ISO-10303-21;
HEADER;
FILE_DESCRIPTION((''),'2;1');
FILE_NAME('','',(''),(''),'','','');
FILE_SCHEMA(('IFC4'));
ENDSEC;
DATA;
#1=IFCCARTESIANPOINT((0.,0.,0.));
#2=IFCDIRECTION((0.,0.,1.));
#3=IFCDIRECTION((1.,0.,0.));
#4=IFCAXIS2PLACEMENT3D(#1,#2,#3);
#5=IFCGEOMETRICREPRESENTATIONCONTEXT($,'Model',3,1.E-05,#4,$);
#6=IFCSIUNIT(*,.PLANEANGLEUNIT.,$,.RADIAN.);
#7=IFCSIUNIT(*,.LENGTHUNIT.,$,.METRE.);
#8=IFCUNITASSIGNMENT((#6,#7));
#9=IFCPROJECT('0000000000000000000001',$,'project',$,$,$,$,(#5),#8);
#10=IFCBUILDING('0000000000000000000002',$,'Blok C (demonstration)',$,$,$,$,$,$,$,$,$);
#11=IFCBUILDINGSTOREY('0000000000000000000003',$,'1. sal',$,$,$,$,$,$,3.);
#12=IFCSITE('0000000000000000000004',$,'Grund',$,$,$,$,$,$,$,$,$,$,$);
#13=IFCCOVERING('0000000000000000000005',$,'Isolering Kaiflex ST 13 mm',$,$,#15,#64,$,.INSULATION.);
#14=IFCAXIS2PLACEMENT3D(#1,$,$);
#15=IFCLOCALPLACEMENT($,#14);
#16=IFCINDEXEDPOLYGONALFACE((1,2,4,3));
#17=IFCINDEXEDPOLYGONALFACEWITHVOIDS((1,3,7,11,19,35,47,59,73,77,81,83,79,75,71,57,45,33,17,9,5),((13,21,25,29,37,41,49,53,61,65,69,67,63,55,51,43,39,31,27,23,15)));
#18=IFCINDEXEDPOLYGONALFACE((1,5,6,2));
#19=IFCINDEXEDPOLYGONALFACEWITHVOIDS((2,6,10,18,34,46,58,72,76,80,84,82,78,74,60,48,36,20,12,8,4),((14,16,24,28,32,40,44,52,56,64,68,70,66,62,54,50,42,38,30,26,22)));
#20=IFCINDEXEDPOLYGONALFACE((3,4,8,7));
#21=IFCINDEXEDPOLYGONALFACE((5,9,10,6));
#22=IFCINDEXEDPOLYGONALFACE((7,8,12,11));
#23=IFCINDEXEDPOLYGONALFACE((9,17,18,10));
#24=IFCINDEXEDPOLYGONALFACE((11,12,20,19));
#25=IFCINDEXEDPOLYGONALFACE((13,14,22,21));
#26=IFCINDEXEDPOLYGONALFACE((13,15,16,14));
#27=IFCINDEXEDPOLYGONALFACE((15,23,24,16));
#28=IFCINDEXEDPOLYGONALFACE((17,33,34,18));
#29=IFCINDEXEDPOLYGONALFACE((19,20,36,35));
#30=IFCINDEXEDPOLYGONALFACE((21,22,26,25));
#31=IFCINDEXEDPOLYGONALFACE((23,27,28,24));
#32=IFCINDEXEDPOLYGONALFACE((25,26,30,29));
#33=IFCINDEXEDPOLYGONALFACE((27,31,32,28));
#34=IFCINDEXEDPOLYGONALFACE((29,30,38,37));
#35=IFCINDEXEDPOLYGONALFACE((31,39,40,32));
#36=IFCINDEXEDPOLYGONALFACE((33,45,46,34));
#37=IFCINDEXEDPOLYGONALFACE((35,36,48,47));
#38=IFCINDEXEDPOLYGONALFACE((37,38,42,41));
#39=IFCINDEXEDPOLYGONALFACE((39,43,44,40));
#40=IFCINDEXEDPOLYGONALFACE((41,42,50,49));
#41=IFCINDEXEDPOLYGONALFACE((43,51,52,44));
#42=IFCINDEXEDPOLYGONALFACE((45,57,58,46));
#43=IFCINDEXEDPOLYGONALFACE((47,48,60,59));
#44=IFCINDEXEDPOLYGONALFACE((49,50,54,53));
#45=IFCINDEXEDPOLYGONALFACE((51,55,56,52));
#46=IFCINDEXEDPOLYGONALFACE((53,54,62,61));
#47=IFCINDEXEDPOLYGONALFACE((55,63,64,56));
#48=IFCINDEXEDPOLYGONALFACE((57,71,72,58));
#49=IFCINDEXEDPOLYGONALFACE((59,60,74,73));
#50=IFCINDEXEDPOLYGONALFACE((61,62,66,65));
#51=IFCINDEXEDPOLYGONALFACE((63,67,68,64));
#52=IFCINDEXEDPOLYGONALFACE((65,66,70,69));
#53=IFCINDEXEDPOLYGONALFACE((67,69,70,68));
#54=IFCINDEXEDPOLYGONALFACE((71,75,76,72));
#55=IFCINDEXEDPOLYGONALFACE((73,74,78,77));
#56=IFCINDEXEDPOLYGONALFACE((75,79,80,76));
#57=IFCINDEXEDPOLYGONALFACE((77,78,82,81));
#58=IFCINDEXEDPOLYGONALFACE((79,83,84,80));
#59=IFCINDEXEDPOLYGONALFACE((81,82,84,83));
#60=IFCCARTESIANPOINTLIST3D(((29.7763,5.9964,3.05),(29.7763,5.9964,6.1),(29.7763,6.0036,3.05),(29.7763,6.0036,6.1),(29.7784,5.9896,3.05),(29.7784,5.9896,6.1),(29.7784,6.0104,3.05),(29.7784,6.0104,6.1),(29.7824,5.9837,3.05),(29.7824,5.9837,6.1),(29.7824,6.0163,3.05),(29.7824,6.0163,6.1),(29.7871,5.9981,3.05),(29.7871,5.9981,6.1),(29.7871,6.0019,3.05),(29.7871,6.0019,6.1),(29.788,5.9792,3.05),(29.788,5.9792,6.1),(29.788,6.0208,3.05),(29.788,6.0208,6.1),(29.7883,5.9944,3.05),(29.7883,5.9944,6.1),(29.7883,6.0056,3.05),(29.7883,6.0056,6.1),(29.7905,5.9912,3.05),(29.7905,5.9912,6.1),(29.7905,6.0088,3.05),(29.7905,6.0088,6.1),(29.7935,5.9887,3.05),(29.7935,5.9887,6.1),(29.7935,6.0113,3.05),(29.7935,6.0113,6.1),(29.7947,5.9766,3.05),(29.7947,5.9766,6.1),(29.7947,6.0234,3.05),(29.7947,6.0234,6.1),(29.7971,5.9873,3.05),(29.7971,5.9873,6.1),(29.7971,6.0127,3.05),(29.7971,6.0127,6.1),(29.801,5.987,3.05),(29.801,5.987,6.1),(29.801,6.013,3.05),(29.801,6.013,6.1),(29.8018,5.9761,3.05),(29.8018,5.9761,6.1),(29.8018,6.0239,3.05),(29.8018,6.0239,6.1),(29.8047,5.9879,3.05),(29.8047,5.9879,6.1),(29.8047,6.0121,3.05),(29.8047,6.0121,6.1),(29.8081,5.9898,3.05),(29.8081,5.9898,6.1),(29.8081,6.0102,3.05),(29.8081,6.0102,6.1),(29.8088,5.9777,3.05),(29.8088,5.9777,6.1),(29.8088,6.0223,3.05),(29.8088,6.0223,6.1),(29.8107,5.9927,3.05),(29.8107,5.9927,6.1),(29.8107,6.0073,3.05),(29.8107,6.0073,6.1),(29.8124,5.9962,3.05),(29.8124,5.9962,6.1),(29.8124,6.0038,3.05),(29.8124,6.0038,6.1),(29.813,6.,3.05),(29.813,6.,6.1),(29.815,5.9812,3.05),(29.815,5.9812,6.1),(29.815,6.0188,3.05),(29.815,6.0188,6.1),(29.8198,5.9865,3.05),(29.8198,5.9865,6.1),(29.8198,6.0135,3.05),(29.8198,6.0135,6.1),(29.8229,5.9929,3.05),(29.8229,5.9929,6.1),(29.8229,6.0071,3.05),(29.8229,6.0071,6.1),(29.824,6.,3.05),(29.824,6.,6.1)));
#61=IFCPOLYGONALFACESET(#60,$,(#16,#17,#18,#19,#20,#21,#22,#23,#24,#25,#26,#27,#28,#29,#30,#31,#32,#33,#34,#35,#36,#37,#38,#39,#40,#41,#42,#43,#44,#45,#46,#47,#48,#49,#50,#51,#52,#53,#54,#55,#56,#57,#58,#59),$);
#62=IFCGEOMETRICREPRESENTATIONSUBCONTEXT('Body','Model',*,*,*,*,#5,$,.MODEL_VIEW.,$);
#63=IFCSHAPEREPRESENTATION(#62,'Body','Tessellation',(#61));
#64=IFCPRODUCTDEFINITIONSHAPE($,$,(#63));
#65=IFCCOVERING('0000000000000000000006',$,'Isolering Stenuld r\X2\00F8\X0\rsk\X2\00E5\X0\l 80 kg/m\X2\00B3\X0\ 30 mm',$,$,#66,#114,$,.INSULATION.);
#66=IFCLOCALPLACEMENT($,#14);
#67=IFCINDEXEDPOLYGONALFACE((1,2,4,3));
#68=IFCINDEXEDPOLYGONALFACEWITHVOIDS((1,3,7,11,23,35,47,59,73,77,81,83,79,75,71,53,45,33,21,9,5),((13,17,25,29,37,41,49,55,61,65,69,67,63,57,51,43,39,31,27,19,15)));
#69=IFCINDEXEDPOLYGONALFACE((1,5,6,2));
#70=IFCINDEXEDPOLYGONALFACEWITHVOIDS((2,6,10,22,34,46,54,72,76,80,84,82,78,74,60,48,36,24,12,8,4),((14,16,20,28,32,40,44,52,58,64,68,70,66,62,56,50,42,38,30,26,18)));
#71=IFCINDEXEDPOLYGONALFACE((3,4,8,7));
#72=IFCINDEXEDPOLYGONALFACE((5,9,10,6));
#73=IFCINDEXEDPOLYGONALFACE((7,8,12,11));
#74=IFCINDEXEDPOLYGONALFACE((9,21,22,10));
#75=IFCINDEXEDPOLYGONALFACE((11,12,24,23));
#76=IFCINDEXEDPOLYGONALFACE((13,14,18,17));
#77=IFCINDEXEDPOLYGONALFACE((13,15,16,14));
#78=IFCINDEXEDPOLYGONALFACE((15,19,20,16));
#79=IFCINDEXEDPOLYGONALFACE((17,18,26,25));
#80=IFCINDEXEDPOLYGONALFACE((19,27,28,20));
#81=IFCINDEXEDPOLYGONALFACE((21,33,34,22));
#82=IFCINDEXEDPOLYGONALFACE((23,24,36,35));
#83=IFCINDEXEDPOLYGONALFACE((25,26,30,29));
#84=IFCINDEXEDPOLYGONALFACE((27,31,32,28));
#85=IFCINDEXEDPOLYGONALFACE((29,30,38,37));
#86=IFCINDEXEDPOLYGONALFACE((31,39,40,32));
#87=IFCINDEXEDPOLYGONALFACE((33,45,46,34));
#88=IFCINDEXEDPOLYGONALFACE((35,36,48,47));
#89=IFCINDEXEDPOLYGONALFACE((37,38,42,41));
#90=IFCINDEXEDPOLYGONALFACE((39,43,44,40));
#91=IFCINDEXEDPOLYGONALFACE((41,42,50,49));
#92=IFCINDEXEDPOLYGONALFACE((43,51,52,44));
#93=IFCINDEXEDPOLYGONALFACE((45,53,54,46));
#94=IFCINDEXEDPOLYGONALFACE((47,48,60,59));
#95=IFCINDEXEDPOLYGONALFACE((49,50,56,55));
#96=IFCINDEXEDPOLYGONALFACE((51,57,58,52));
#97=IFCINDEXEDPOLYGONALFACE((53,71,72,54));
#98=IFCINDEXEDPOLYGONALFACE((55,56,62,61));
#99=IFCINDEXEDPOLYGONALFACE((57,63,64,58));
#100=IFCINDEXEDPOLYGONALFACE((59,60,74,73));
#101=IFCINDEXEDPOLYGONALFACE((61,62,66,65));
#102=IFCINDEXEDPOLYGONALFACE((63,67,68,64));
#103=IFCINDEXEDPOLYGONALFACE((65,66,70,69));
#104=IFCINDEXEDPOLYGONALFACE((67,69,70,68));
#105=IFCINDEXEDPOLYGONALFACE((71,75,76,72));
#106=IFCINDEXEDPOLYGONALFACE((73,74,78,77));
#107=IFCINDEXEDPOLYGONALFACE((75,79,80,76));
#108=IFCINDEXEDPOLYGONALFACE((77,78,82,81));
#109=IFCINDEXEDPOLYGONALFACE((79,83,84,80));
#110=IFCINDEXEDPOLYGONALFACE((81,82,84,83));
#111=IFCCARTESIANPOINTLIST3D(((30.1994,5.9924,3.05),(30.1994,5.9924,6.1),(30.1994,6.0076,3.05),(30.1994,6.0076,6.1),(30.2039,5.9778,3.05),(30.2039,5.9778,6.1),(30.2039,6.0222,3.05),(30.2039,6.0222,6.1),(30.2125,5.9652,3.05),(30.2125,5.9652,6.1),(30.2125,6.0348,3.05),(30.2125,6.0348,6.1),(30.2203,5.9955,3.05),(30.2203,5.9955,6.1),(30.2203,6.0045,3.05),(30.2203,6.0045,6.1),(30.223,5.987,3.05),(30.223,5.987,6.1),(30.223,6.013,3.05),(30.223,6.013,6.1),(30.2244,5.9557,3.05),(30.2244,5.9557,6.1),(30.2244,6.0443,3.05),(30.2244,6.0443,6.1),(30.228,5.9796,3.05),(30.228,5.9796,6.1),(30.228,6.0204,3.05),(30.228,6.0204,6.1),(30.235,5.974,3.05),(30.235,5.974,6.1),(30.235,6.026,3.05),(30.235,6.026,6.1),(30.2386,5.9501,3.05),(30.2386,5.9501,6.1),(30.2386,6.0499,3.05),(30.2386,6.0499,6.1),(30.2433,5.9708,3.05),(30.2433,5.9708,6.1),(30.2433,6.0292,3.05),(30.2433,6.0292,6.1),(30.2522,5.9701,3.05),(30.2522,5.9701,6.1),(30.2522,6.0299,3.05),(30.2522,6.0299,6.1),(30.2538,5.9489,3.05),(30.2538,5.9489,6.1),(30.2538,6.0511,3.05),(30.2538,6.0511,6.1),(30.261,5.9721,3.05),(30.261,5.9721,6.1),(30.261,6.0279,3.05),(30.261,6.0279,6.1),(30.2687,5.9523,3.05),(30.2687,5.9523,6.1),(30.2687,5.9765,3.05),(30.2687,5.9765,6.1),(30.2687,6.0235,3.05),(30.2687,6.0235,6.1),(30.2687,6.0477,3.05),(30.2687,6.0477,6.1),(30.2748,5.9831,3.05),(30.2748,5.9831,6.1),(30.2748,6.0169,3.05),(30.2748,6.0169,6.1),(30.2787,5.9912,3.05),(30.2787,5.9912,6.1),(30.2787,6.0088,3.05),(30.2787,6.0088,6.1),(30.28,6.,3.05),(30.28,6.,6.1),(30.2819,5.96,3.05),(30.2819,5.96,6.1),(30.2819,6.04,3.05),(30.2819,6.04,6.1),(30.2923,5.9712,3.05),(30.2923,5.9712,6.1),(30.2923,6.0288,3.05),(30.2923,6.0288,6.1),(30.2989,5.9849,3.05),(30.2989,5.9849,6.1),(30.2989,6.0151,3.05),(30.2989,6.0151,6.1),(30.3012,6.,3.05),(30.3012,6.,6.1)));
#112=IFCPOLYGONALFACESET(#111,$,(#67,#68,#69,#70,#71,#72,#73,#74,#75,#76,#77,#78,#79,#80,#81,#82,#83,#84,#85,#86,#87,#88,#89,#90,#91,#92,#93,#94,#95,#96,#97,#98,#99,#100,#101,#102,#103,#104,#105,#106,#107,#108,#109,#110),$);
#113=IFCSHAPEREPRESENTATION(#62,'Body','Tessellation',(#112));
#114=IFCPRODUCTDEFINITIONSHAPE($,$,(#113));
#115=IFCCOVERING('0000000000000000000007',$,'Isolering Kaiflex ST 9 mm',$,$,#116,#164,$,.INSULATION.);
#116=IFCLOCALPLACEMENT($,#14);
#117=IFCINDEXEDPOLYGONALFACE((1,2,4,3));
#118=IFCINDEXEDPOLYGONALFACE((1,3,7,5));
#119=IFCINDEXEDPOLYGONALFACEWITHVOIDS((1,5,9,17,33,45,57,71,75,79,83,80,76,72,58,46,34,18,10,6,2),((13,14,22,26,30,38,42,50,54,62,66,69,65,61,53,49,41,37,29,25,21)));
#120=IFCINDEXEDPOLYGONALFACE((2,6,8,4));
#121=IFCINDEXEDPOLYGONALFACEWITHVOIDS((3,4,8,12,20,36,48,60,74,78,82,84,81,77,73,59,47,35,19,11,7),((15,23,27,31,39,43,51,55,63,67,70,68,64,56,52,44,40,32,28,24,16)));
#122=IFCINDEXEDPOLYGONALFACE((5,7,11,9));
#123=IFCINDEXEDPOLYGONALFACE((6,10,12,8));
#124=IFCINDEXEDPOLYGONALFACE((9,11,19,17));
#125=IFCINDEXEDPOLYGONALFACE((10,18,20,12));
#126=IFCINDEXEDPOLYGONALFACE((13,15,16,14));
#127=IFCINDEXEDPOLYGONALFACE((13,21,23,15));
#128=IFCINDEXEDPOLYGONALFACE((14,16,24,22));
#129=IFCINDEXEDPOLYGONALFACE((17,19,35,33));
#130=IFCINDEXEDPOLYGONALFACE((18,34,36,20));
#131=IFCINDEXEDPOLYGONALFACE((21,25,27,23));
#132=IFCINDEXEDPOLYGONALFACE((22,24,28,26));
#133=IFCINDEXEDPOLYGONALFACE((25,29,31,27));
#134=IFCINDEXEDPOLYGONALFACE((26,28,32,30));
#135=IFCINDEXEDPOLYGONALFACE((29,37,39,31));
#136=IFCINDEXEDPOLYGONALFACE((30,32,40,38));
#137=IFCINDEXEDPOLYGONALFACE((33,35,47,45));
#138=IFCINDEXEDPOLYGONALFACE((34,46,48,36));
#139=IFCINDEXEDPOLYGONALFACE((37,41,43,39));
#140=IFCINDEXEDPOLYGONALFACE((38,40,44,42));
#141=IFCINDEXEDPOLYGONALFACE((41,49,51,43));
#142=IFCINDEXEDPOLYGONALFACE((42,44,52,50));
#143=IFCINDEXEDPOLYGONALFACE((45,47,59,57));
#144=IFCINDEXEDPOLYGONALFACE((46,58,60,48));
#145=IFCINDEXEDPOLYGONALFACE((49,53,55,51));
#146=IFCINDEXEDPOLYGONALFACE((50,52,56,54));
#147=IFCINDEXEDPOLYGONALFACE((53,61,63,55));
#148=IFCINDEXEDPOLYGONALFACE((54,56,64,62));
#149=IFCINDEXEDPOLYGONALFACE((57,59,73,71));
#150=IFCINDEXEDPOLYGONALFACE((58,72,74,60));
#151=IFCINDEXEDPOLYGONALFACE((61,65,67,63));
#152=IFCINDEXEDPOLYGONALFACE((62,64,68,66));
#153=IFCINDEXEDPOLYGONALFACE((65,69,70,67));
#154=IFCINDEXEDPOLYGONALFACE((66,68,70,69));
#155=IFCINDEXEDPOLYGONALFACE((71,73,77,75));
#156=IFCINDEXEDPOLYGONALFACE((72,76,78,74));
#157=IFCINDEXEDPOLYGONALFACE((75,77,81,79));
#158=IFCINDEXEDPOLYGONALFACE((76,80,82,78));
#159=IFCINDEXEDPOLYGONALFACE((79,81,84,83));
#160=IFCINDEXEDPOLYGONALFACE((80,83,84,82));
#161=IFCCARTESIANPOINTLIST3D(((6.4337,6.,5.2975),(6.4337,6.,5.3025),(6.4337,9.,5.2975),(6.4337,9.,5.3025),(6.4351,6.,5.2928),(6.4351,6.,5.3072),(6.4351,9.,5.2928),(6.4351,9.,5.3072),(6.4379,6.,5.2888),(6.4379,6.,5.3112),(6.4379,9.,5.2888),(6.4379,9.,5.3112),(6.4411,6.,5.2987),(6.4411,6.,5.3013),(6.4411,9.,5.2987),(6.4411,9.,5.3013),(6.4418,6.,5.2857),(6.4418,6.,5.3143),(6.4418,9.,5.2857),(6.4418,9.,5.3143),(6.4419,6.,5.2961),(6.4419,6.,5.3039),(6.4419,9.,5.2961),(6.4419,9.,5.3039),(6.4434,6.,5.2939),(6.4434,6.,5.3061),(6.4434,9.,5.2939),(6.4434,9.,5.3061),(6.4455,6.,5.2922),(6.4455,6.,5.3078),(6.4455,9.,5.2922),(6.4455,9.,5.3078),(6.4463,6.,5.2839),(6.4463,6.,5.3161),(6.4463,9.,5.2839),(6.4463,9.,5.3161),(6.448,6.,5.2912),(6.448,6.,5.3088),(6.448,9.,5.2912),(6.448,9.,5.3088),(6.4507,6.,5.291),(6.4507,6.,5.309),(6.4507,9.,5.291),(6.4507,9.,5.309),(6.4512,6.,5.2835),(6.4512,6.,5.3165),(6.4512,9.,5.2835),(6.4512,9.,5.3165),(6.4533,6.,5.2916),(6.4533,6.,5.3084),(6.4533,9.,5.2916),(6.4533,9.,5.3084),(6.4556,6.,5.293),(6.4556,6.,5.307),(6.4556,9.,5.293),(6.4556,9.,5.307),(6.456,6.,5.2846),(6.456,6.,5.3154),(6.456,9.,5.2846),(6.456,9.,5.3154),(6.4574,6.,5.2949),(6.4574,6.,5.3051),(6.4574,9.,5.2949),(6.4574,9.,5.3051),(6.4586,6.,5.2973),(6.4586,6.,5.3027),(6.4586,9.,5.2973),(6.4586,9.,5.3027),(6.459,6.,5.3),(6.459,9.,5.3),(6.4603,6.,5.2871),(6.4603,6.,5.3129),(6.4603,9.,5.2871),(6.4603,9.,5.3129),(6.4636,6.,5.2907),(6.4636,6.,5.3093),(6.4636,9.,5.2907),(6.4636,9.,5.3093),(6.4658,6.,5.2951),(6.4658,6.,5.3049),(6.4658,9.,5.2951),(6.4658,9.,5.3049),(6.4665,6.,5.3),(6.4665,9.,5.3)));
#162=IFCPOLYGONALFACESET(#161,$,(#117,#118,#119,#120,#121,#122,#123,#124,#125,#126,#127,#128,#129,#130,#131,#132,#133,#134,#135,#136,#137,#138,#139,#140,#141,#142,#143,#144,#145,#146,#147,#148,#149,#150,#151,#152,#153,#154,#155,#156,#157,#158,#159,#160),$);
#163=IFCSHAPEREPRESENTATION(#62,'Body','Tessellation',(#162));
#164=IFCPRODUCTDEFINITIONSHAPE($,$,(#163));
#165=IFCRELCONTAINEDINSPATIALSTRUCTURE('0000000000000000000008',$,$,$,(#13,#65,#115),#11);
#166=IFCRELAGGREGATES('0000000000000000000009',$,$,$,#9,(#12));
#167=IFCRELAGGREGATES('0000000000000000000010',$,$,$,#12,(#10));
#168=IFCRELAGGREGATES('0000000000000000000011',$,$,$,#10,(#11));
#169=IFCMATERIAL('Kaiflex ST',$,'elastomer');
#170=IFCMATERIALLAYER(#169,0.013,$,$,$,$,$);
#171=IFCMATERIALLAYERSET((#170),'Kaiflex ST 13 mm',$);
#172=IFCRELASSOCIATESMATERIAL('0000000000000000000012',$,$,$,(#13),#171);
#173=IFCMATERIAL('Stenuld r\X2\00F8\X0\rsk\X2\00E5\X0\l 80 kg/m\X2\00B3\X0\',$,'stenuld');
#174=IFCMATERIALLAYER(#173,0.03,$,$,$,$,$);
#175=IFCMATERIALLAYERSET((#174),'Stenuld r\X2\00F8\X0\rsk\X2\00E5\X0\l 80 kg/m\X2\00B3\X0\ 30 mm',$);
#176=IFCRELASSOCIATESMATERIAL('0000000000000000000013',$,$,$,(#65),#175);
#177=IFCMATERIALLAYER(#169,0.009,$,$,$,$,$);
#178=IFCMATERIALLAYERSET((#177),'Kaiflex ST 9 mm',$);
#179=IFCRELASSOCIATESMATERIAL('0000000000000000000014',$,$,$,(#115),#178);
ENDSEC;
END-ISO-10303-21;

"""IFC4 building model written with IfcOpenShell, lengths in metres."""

from ifc_helpers import new_model, si_unit, frame, origin_with_axes, place, context, subcontext, project, spatial, hollow_circle, extrude, material, layer, layer_set, element, save


model = new_model("IFC4")

# Units and contexts
model_context = context("Model", 3, precision=1e-05, world=origin_with_axes())
body_context = subcontext(model_context, "Body", "Model", "MODEL_VIEW")
ifc_project = project(units=[si_unit("PLANEANGLEUNIT", "RADIAN"), si_unit("LENGTHUNIT", "METRE")], contexts=[model_context])

# Site, building, storey
site = spatial("IfcSite", under=ifc_project, Name="Grund")
building = spatial("IfcBuilding", under=site, Name="Blok C (demonstration)")
storey = spatial("IfcBuildingStorey", under=building, Name="1. sal", Elevation=3.0)

# Coverings
ifc_material_1 = material(Name="Stenuld rørskål 80 kg/m³", Category="stenuld")
ifc_material_2 = material(Name="Kaiflex ST", Category="elastomer")
ifc_layer_1 = layer(ifc_material_2, 0.013)
ifc_layer_set_1 = layer_set([ifc_layer_1], Name="Kaiflex ST 13 mm")
covering_1_placement = place(None, origin_with_axes())
element("IfcCovering", 1, at=covering_1_placement, inside=storey, material=ifc_layer_set_1, Name="Isolering Kaiflex ST 13 mm", PredefinedType="INSULATION", context=body_context, shape_type="SweptSolid", body=[
    extrude(hollow_circle(Radius=0.024, WallThickness=0.011), frame((29.8, 6.0, 3.05), z_axis=(0.0, 0.0, 1.0), x_axis=(1.0, 0.0, 0.0)), (0.0, 0.0, 1.0), 3.05),
])
ifc_layer_2 = layer(ifc_material_1, 0.03)
ifc_layer_set_2 = layer_set([ifc_layer_2], Name="Stenuld rørskål 80 kg/m³ 30 mm")
covering_2_placement = place(None, origin_with_axes())
element("IfcCovering", 2, at=covering_2_placement, inside=storey, material=ifc_layer_set_2, Name="Isolering Stenuld rørskål 80 kg/m³ 30 mm", PredefinedType="INSULATION", context=body_context, shape_type="SweptSolid", body=[
    extrude(hollow_circle(Radius=0.0512, WallThickness=0.0212), frame((30.25, 6.0, 3.05), z_axis=(0.0, 0.0, 1.0), x_axis=(1.0, 0.0, 0.0)), (0.0, 0.0, 1.0), 3.05),
])
ifc_layer_3 = layer(ifc_material_2, 0.009)
ifc_layer_set_3 = layer_set([ifc_layer_3], Name="Kaiflex ST 9 mm")
covering_3_placement = place(None, origin_with_axes())
element("IfcCovering", 3, at=covering_3_placement, inside=storey, material=ifc_layer_set_3, Name="Isolering Kaiflex ST 9 mm", PredefinedType="INSULATION", context=body_context, shape_type="SweptSolid", body=[
    extrude(hollow_circle(Radius=0.0165, WallThickness=0.0075), frame((6.45, 6.0, 5.3), z_axis=(0.0, 1.0, 0.0), x_axis=(1.0, 0.0, 0.0)), (0.0, 0.0, 1.0), 3.0),
])

save(model, "model.ifc")
